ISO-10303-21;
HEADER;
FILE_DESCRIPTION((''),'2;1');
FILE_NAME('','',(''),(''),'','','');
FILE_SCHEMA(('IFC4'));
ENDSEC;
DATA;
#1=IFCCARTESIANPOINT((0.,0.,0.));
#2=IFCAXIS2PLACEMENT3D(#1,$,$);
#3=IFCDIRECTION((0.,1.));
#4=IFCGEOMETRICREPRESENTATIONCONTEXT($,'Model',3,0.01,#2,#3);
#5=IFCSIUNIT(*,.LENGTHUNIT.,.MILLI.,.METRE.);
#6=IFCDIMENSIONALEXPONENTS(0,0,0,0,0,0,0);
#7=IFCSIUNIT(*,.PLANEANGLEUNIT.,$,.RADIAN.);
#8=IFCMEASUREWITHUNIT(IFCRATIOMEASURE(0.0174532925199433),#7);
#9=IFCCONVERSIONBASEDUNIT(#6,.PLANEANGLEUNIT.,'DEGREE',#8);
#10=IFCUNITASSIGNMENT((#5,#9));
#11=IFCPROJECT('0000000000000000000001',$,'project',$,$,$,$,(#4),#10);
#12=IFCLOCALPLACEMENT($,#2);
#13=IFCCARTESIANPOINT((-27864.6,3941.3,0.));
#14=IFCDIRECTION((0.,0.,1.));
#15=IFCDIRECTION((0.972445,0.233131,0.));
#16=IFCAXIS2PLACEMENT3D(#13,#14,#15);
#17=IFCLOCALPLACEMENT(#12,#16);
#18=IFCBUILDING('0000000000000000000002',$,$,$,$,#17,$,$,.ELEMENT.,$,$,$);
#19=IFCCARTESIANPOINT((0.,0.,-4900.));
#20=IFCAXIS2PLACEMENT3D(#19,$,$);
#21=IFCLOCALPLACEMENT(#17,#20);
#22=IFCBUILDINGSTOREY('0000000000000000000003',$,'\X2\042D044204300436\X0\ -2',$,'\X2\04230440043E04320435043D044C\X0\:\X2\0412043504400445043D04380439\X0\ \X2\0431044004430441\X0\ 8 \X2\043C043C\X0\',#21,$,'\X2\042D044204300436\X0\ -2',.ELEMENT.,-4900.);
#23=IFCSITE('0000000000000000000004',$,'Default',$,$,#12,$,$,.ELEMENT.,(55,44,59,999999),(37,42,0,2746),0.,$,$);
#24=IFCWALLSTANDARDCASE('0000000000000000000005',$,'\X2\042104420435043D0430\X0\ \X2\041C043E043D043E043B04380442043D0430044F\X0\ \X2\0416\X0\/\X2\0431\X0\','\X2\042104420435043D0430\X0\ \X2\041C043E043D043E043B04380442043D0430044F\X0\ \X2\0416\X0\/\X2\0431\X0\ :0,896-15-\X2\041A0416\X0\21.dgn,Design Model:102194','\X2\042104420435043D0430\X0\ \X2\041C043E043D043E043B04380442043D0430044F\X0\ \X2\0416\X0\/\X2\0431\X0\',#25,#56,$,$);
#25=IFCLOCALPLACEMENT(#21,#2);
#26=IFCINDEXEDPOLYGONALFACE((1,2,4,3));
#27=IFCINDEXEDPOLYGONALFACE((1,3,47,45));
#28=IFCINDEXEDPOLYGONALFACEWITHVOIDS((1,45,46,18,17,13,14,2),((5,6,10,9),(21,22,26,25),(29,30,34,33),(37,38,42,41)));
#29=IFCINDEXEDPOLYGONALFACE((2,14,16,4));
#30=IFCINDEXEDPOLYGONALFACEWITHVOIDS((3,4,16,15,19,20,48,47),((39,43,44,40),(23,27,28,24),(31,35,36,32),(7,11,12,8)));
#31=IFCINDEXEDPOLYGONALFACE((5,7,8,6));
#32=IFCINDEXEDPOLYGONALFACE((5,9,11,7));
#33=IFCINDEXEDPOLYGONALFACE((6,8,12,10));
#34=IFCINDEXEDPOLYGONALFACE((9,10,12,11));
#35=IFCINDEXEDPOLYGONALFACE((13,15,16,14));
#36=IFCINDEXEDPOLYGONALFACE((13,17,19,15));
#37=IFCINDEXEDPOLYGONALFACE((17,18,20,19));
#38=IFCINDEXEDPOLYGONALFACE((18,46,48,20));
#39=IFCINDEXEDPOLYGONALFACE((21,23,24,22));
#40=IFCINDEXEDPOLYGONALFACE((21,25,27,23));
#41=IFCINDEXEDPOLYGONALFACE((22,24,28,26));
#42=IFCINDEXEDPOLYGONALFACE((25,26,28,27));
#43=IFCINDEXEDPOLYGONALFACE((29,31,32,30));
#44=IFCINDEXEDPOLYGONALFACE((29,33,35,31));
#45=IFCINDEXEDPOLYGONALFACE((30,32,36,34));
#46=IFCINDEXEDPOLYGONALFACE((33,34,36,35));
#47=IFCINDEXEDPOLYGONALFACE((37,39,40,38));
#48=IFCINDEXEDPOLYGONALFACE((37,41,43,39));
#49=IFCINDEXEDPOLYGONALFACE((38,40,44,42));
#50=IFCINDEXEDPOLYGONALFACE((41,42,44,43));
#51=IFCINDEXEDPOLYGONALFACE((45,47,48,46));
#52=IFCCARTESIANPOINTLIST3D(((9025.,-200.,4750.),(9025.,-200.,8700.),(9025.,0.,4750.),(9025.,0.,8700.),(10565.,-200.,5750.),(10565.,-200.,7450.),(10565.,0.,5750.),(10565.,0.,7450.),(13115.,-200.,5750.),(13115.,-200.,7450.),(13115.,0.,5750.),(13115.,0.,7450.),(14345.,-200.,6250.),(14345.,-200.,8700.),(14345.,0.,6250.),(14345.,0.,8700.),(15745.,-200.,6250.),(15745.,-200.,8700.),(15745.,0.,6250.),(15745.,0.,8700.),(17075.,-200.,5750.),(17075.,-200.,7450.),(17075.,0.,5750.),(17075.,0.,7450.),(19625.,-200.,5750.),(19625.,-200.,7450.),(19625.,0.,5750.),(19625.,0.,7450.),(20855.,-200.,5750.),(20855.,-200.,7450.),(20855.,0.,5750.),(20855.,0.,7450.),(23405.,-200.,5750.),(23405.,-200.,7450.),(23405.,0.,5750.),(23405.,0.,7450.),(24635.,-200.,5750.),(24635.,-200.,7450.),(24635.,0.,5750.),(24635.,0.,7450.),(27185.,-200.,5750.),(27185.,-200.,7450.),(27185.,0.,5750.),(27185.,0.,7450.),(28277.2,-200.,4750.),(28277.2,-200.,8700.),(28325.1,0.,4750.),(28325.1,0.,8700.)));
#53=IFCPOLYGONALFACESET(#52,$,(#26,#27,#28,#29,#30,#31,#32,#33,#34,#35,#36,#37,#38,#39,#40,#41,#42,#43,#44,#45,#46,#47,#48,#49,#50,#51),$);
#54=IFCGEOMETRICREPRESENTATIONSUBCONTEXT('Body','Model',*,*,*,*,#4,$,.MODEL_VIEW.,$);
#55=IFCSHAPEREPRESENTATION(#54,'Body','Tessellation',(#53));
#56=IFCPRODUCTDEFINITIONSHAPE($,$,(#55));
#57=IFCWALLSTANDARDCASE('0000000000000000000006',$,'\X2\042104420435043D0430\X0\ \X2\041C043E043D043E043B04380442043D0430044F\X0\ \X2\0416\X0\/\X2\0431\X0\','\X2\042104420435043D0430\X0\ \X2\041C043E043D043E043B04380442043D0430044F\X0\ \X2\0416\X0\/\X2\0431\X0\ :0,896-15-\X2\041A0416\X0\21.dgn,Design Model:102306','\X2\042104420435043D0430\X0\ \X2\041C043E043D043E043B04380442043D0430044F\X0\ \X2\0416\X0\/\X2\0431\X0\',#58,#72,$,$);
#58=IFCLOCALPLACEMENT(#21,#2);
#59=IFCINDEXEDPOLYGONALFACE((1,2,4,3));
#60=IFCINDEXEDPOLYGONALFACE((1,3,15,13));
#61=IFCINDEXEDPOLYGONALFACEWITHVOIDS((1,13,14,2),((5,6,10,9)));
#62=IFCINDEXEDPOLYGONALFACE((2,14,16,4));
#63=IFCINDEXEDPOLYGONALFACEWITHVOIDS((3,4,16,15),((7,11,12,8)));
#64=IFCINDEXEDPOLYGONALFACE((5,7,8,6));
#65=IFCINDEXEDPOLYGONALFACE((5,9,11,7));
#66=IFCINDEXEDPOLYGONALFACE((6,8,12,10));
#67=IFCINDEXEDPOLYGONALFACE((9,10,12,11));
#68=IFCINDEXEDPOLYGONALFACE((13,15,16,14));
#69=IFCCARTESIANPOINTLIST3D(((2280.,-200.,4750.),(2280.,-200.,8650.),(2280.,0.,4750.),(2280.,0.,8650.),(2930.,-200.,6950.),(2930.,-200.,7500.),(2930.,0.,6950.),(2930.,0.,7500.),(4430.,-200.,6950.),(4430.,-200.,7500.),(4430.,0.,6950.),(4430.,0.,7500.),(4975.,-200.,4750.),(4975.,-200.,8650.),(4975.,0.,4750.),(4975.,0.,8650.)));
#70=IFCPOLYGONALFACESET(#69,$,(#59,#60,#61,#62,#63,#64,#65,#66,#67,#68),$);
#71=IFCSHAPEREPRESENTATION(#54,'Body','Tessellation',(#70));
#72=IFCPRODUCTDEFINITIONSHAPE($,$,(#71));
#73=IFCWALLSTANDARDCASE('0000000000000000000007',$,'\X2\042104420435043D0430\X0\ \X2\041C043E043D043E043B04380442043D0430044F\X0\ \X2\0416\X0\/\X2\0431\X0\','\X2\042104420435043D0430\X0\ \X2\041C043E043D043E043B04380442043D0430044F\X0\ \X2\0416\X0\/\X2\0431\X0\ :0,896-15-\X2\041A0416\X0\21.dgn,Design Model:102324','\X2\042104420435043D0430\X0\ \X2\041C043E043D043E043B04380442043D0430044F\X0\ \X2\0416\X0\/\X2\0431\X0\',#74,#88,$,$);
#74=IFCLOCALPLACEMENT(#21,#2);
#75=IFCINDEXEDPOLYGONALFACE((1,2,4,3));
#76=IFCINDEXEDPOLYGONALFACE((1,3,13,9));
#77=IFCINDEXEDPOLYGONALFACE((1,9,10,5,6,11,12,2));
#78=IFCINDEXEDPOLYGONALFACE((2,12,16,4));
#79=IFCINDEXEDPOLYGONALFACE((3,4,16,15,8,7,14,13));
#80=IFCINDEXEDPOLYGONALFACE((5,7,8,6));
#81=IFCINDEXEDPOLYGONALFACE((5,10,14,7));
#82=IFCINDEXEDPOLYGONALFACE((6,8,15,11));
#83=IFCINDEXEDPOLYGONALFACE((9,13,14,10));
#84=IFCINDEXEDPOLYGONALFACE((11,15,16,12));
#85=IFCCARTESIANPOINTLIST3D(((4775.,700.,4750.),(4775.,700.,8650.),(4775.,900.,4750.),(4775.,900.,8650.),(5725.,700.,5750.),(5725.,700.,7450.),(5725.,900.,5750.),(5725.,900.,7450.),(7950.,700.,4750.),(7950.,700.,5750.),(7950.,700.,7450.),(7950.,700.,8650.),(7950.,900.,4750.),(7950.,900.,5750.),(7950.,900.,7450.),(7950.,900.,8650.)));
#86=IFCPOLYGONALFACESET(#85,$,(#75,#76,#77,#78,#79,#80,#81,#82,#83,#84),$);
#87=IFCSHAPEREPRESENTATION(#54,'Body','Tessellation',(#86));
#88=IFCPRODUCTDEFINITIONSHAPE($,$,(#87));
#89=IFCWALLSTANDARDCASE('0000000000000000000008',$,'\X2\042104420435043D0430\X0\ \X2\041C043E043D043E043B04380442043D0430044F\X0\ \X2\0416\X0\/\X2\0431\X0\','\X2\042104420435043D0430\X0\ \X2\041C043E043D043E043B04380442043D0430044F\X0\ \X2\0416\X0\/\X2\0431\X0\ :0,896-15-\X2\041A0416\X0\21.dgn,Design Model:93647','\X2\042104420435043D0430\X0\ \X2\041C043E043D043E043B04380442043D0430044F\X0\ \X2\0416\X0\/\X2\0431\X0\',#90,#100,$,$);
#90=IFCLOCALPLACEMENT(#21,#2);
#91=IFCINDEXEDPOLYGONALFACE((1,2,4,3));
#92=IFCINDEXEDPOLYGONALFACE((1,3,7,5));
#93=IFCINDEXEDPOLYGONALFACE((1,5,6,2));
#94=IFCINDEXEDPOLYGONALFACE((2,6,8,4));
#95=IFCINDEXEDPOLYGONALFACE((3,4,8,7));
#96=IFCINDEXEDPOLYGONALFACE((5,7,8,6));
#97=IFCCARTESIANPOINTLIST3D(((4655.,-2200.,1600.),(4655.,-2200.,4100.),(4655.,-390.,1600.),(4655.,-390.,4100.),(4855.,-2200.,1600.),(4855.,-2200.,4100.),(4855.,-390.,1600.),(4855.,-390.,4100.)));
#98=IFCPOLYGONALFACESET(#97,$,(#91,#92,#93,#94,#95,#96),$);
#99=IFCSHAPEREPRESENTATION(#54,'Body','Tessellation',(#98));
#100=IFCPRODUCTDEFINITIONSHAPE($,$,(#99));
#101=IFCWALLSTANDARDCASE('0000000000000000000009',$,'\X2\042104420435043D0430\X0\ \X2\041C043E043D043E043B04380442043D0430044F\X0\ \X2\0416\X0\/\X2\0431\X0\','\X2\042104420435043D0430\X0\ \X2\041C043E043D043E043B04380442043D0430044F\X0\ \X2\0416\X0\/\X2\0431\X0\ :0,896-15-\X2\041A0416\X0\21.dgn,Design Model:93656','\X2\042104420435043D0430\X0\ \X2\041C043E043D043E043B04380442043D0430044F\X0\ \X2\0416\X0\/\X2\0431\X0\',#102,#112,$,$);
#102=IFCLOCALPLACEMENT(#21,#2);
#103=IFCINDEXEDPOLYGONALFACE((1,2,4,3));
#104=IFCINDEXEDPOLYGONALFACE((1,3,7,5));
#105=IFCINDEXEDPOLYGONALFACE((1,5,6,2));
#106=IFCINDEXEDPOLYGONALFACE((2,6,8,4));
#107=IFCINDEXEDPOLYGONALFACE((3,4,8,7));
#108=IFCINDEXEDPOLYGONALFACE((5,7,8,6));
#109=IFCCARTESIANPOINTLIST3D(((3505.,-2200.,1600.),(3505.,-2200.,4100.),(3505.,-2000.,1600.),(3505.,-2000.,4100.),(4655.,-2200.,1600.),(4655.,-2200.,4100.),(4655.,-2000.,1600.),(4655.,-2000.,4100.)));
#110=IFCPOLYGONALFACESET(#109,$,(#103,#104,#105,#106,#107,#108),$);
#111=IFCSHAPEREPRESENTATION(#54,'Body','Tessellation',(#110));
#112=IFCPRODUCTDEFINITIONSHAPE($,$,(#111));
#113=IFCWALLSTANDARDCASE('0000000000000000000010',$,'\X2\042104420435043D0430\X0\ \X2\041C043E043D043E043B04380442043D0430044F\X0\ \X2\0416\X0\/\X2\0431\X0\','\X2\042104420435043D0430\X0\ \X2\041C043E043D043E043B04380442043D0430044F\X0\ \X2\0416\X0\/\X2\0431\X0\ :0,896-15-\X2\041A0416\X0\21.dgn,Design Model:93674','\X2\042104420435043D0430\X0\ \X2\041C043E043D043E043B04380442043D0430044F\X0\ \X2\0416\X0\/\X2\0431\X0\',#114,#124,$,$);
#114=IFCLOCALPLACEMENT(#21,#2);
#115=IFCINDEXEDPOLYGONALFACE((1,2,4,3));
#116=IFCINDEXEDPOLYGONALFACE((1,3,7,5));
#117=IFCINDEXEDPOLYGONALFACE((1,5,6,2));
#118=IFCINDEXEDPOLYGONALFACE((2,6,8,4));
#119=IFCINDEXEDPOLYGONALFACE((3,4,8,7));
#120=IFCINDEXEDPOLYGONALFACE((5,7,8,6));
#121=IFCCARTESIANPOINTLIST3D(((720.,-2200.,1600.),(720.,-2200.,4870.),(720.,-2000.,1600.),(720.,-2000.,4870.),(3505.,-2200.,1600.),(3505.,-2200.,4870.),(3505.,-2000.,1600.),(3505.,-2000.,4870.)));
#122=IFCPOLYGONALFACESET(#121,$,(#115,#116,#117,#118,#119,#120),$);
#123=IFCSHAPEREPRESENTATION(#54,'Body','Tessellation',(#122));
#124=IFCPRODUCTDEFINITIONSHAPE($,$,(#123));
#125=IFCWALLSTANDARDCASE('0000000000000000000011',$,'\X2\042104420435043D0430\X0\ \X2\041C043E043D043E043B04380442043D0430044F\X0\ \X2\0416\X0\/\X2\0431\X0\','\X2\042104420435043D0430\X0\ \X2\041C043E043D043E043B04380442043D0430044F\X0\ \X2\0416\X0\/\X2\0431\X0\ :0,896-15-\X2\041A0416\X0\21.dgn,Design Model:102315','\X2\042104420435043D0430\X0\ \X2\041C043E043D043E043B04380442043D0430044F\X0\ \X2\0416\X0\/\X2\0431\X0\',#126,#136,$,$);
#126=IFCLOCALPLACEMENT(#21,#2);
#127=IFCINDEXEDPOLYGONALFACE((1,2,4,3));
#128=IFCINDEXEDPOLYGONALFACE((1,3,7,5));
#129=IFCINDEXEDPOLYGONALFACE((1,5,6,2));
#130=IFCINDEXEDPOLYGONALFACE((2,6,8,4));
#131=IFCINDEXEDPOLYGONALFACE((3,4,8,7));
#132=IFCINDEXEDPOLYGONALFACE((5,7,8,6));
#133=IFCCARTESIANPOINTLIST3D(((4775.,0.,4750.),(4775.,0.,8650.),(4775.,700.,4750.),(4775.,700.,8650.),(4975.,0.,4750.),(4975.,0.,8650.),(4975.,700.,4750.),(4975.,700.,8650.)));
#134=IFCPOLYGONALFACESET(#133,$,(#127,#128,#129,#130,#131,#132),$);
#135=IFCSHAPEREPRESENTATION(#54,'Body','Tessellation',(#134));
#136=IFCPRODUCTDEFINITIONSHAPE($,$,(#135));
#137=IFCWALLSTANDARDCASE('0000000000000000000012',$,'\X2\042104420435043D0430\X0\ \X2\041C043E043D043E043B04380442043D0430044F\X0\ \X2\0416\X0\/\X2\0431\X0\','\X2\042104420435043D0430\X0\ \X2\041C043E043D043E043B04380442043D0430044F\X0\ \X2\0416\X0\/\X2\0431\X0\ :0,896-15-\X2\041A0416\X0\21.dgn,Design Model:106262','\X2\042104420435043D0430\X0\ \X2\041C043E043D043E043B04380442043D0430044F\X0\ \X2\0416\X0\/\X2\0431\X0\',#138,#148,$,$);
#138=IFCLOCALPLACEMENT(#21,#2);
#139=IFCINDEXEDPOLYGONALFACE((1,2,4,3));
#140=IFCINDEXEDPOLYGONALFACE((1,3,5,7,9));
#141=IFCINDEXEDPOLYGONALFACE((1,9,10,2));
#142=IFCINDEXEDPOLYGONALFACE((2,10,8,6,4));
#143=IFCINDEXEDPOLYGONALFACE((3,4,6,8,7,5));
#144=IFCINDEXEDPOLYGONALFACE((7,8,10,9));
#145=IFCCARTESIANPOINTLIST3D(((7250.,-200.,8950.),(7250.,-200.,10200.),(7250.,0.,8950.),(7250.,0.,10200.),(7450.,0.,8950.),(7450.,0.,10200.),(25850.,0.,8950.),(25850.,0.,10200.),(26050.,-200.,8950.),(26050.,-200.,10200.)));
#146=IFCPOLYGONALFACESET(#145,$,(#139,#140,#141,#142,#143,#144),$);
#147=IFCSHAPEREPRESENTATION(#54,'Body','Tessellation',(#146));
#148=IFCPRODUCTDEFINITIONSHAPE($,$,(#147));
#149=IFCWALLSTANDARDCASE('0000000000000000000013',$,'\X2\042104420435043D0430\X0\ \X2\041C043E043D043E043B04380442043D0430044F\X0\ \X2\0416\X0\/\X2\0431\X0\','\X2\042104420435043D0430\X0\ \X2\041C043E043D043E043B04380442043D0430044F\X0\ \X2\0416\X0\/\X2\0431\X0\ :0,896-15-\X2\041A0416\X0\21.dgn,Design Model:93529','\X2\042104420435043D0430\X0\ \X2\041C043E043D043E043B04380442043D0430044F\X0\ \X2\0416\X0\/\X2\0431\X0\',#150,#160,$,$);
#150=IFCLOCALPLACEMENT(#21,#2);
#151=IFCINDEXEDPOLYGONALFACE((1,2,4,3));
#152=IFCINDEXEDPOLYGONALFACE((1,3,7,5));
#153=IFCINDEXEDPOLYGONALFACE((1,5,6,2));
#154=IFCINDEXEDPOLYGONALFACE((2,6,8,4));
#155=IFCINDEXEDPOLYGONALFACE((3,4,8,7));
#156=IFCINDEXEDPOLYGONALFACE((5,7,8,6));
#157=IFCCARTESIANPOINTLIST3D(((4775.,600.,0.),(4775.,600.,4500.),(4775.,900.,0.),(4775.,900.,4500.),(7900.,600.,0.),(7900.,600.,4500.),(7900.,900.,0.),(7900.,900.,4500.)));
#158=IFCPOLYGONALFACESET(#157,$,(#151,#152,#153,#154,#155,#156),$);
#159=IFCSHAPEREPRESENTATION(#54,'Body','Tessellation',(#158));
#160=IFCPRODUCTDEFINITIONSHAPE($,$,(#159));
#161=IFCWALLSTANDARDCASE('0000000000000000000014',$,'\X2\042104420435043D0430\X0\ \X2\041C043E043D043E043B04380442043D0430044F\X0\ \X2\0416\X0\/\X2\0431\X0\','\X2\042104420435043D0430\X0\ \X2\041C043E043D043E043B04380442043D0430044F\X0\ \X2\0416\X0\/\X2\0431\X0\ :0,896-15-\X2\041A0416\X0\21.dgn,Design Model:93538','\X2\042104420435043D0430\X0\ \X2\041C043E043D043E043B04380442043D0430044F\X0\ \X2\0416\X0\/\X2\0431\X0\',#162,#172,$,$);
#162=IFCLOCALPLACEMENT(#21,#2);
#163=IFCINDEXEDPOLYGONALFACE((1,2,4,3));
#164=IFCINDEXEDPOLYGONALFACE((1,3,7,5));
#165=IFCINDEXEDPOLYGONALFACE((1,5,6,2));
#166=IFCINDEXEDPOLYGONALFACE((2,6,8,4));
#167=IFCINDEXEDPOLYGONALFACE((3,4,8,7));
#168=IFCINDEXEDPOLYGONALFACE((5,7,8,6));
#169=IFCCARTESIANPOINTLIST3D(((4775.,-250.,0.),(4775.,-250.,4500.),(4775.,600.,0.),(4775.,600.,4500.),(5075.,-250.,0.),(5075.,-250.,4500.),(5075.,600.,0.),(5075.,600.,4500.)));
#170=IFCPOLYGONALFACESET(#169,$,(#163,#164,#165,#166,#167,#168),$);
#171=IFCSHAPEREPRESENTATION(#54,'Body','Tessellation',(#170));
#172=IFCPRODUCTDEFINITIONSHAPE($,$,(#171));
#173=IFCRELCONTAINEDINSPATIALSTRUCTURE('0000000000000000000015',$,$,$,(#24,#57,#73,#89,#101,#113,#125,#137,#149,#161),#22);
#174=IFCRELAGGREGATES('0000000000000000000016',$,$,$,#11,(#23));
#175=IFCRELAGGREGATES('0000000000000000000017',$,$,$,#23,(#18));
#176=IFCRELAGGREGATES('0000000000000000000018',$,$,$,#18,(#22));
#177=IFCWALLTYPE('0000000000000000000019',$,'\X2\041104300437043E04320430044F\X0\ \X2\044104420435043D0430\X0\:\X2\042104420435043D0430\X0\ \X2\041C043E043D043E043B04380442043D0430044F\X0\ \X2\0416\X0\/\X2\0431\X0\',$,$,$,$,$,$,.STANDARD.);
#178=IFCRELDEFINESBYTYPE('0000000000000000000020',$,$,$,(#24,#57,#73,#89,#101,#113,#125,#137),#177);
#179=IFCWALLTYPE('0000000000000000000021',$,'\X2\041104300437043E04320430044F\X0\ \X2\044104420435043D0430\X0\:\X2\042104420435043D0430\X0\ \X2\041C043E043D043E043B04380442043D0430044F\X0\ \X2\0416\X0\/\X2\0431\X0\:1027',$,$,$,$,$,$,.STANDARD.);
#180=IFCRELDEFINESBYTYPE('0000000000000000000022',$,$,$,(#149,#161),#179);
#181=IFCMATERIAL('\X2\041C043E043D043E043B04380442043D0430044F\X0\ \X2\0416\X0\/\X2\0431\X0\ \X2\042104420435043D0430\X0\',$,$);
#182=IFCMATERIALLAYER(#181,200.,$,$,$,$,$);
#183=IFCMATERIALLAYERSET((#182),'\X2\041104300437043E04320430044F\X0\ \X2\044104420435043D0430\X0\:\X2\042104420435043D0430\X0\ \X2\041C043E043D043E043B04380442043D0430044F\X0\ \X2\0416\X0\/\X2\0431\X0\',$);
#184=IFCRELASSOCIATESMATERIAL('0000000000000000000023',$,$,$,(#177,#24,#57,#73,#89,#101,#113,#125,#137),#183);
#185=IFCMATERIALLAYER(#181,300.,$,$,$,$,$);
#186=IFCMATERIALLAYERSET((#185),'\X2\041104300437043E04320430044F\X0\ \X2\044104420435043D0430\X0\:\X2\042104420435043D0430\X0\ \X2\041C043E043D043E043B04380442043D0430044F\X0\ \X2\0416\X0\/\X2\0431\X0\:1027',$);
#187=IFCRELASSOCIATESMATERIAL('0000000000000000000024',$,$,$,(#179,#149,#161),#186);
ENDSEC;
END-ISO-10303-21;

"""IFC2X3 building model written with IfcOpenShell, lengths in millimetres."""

from ifc_helpers import new_model, entity, si_unit, converted_unit, direction, frame, frame_2d, origin, origin_2d_with_axis, place, context, subcontext, project, spatial, polyline, rectangle, outline, extrude, material, layer, layer_set, layer_usage, type_object, element, save


model = new_model("IFC2X3")

# Units and contexts
model_context = context("Model", 3, precision=0.01, world=origin(), true_north=direction((0.0, 1.0)))
body_context = subcontext(model_context, "Body", "Model", "MODEL_VIEW")
ifc_project = project(units=[si_unit("LENGTHUNIT", "METRE", prefix="MILLI"), converted_unit("PLANEANGLEUNIT", "DEGREE", entity("IfcRatioMeasure", 0.0174532925199433), si_unit("PLANEANGLEUNIT", "RADIAN"), dimensions=[0, 0, 0, 0, 0, 0, 0])], contexts=[model_context])

# Site, building, storey
site_placement = place(None, origin())
site = spatial("IfcSite", under=ifc_project, at=site_placement, Name="Default", CompositionType="ELEMENT", RefLatitude=(55, 44, 59, 999999), RefLongitude=(37, 42, 0, 2746), RefElevation=0.0)
building_placement = place(site_placement, frame((-27864.6, 3941.3, 0.0), z_axis=(0.0, 0.0, 1.0), x_axis=(0.972445, 0.233131, 0.0)))
building = spatial("IfcBuilding", under=site, at=building_placement, CompositionType="ELEMENT")
storey_placement = place(building_placement, frame((0.0, 0.0, -4900.0)))
storey = spatial("IfcBuildingStorey", under=building, at=storey_placement, Name="Этаж -2", ObjectType="Уровень:Верхний брус 8 мм", LongName="Этаж -2", CompositionType="ELEMENT", Elevation=-4900.0)

# Wall, openings
ifc_material = material(Name="Монолитная Ж/б Стена")
ifc_layer_1 = layer(ifc_material, 200.0)
ifc_layer_set_1 = layer_set([ifc_layer_1], Name="Базовая стена:Стена Монолитная Ж/б")
ifc_layer_usage_1 = layer_usage(ifc_layer_set_1, "AXIS2", "NEGATIVE", 100.0)
wall_type_1 = type_object("IfcWallType", Name="Базовая стена:Стена Монолитная Ж/б", PredefinedType="STANDARD", material=ifc_layer_set_1)
wall_1_placement = place(storey_placement, frame((9025.0, -100.0, 4750.0)))
wall_1 = element("IfcWallStandardCase", 1, at=wall_1_placement, inside=storey, type_object=wall_type_1, material=ifc_layer_usage_1, Name="Стена Монолитная Ж/б", Description="Стена Монолитная Ж/б :0,896-15-КЖ21.dgn,Design Model:102194", ObjectType="Стена Монолитная Ж/б", context=body_context, shape_type="SweptSolid", body=[
    extrude(outline(polyline([(19252.2, -100.0), (19300.1, 100.0), (7130.0, 100.0), (6880.0, 100.0), (200.0, 100.0), (0.0, 100.0), (0.0, -100.0), (19252.2, -100.0)])), origin(), (0.0, 0.0, 1.0), 3950.0),
])
placement = place(wall_1_placement, origin())
element("IfcOpeningElement", 2, at=placement, cuts=wall_1, ObjectType="Opening", context=body_context, shape_type="SweptSolid", body=[
    extrude(rectangle(XDim=1700.0, YDim=2550.0, at=origin_2d_with_axis()), frame((2815.0, -100.0, 1850.0), z_axis=(0.0, 1.0, 0.0), x_axis=(0.0, 0.0, -1.0)), (0.0, 0.0, 1.0), 200.0),
])
element("IfcOpeningElement", 3, at=placement, cuts=wall_1, ObjectType="Opening", context=body_context, shape_type="SweptSolid", body=[
    extrude(rectangle(XDim=1700.0, YDim=2550.0, at=origin_2d_with_axis()), frame((9325.0, -100.0, 1850.0), z_axis=(0.0, 1.0, 0.0), x_axis=(0.0, 0.0, -1.0)), (0.0, 0.0, 1.0), 200.0),
])
element("IfcOpeningElement", 4, at=placement, cuts=wall_1, ObjectType="Opening", context=body_context, shape_type="SweptSolid", body=[
    extrude(rectangle(XDim=1700.0, YDim=2550.0, at=origin_2d_with_axis()), frame((13105.0, -100.0, 1850.0), z_axis=(0.0, 1.0, 0.0), x_axis=(0.0, 0.0, -1.0)), (0.0, 0.0, 1.0), 200.0),
])
element("IfcOpeningElement", 5, at=placement, cuts=wall_1, ObjectType="Opening", context=body_context, shape_type="SweptSolid", body=[
    extrude(rectangle(XDim=1700.0, YDim=2550.0, at=origin_2d_with_axis()), frame((16885.0, -100.0, 1850.0), z_axis=(0.0, 1.0, 0.0), x_axis=(0.0, 0.0, -1.0)), (0.0, 0.0, 1.0), 200.0),
])
element("IfcOpeningElement", 6, at=placement, cuts=wall_1, ObjectType="Opening", context=body_context, shape_type="SweptSolid", body=[
    extrude(rectangle(XDim=2450.0, YDim=1400.0, at=origin_2d_with_axis()), frame((6020.0, -100.0, 2725.0), z_axis=(0.0, 1.0, 0.0), x_axis=(0.0, 0.0, -1.0)), (0.0, 0.0, 1.0), 200.0),
])

# Walls, openings
wall_2_placement = place(storey_placement, frame((4975.0, -100.0, 4750.0), z_axis=(0.0, 0.0, 1.0), x_axis=(-1.0, 0.0, 0.0)))
wall_2 = element("IfcWallStandardCase", 7, at=wall_2_placement, inside=storey, type_object=wall_type_1, material=ifc_layer_usage_1, Name="Стена Монолитная Ж/б", Description="Стена Монолитная Ж/б :0,896-15-КЖ21.dgn,Design Model:102306", ObjectType="Стена Монолитная Ж/б", context=body_context, shape_type="SweptSolid", body=[
    extrude(rectangle(XDim=2695.0, YDim=200.0, at=frame_2d((1347.5, 0.0), x_axis=(-1.0, 0.0))), origin(), (0.0, 0.0, 1.0), 3900.0),
])
opening_1_placement = place(wall_2_placement, origin())
element("IfcOpeningElement", 8, at=opening_1_placement, cuts=wall_2, ObjectType="Opening", context=body_context, shape_type="SweptSolid", body=[
    extrude(rectangle(XDim=550.0, YDim=1500.0, at=origin_2d_with_axis()), frame((1295.0, -100.0, 2475.0), z_axis=(0.0, 1.0, 0.0), x_axis=(0.0, 0.0, -1.0)), (0.0, 0.0, 1.0), 200.0),
])
wall_3_placement = place(storey_placement, frame((4775.0, 800.0, 4750.0)))
wall_3 = element("IfcWallStandardCase", 9, at=wall_3_placement, inside=storey, type_object=wall_type_1, material=ifc_layer_usage_1, Name="Стена Монолитная Ж/б", Description="Стена Монолитная Ж/б :0,896-15-КЖ21.dgn,Design Model:102324", ObjectType="Стена Монолитная Ж/б", context=body_context, shape_type="SweptSolid", body=[
    extrude(rectangle(XDim=3175.0, YDim=200.0, at=frame_2d((1587.5, 0.0), x_axis=(-1.0, 0.0))), origin(), (0.0, 0.0, 1.0), 3900.0),
])
opening_2_placement = place(wall_3_placement, origin())
element("IfcOpeningElement", 10, at=opening_2_placement, cuts=wall_3, ObjectType="Opening", context=body_context, shape_type="SweptSolid", body=[
    extrude(rectangle(XDim=1700.0, YDim=2550.0, at=origin_2d_with_axis()), frame((2225.0, -100.0, 1850.0), z_axis=(0.0, 1.0, 0.0), x_axis=(0.0, 0.0, -1.0)), (0.0, 0.0, 1.0), 200.0),
])

# Walls
wall_4_placement = place(storey_placement, frame((4755.0, -2200.0, 1600.0), z_axis=(0.0, 0.0, 1.0), x_axis=(0.0, 1.0, 0.0)))
element("IfcWallStandardCase", 11, at=wall_4_placement, inside=storey, type_object=wall_type_1, material=ifc_layer_usage_1, Name="Стена Монолитная Ж/б", Description="Стена Монолитная Ж/б :0,896-15-КЖ21.dgn,Design Model:93647", ObjectType="Стена Монолитная Ж/б", context=body_context, shape_type="SweptSolid", body=[
    extrude(rectangle(XDim=1810.0, YDim=200.0, at=frame_2d((905.0, 0.0), x_axis=(-1.0, 0.0))), origin(), (0.0, 0.0, 1.0), 2500.0),
])
wall_5_placement = place(storey_placement, frame((3505.0, -2100.0, 1600.0)))
element("IfcWallStandardCase", 12, at=wall_5_placement, inside=storey, type_object=wall_type_1, material=ifc_layer_usage_1, Name="Стена Монолитная Ж/б", Description="Стена Монолитная Ж/б :0,896-15-КЖ21.dgn,Design Model:93656", ObjectType="Стена Монолитная Ж/б", context=body_context, shape_type="SweptSolid", body=[
    extrude(rectangle(XDim=1150.0, YDim=200.0, at=frame_2d((575.0, 0.0), x_axis=(-1.0, 0.0))), origin(), (0.0, 0.0, 1.0), 2500.0),
])
wall_6_placement = place(storey_placement, frame((3505.0, -2100.0, 1600.0), z_axis=(0.0, 0.0, 1.0), x_axis=(-1.0, 0.0, 0.0)))
element("IfcWallStandardCase", 13, at=wall_6_placement, inside=storey, type_object=wall_type_1, material=ifc_layer_usage_1, Name="Стена Монолитная Ж/б", Description="Стена Монолитная Ж/б :0,896-15-КЖ21.dgn,Design Model:93674", ObjectType="Стена Монолитная Ж/б", context=body_context, shape_type="SweptSolid", body=[
    extrude(rectangle(XDim=2785.0, YDim=200.0, at=frame_2d((1392.5, 0.0), x_axis=(-1.0, 0.0))), origin(), (0.0, 0.0, 1.0), 3270.0),
])
wall_7_placement = place(storey_placement, frame((4875.0, 700.0, 4750.0), z_axis=(0.0, 0.0, 1.0), x_axis=(0.0, -1.0, 0.0)))
element("IfcWallStandardCase", 14, at=wall_7_placement, inside=storey, type_object=wall_type_1, material=ifc_layer_usage_1, Name="Стена Монолитная Ж/б", Description="Стена Монолитная Ж/б :0,896-15-КЖ21.dgn,Design Model:102315", ObjectType="Стена Монолитная Ж/б", context=body_context, shape_type="SweptSolid", body=[
    extrude(rectangle(XDim=700.0, YDim=200.0, at=frame_2d((350.0, 0.0), x_axis=(-1.0, 0.0))), origin(), (0.0, 0.0, 1.0), 3900.0),
])
wall_8_placement = place(storey_placement, frame((7250.0, -100.0, 8950.0)))
element("IfcWallStandardCase", 15, at=wall_8_placement, inside=storey, type_object=wall_type_1, material=ifc_layer_usage_1, Name="Стена Монолитная Ж/б", Description="Стена Монолитная Ж/б :0,896-15-КЖ21.dgn,Design Model:106262", ObjectType="Стена Монолитная Ж/б", context=body_context, shape_type="SweptSolid", body=[
    extrude(outline(polyline([(18800.0, -100.0), (18600.0, 100.0), (200.0, 100.0), (0.0, 100.0), (0.0, -100.0), (18800.0, -100.0)])), origin(), (0.0, 0.0, 1.0), 1250.0),
])
ifc_layer_2 = layer(ifc_material, 300.0)
ifc_layer_set_2 = layer_set([ifc_layer_2], Name="Базовая стена:Стена Монолитная Ж/б:1027")
ifc_layer_usage_2 = layer_usage(ifc_layer_set_2, "AXIS2", "NEGATIVE", 150.0)
wall_type_2 = type_object("IfcWallType", Name="Базовая стена:Стена Монолитная Ж/б:1027", PredefinedType="STANDARD", material=ifc_layer_set_2)
wall_9_placement = place(storey_placement, frame((4775.0, 750.0, 0.0)))
element("IfcWallStandardCase", 16, at=wall_9_placement, inside=storey, type_object=wall_type_2, material=ifc_layer_usage_2, Name="Стена Монолитная Ж/б", Description="Стена Монолитная Ж/б :0,896-15-КЖ21.dgn,Design Model:93529", ObjectType="Стена Монолитная Ж/б", context=body_context, shape_type="SweptSolid", body=[
    extrude(rectangle(XDim=3125.0, YDim=300.0, at=frame_2d((1562.5, 0.0), x_axis=(-1.0, 0.0))), origin(), (0.0, 0.0, 1.0), 4500.0),
])
wall_10_placement = place(storey_placement, frame((4925.0, -250.0, 0.0), z_axis=(0.0, 0.0, 1.0), x_axis=(0.0, 1.0, 0.0)))
element("IfcWallStandardCase", 17, at=wall_10_placement, inside=storey, type_object=wall_type_2, material=ifc_layer_usage_2, Name="Стена Монолитная Ж/б", Description="Стена Монолитная Ж/б :0,896-15-КЖ21.dgn,Design Model:93538", ObjectType="Стена Монолитная Ж/б", context=body_context, shape_type="SweptSolid", body=[
    extrude(rectangle(XDim=850.0, YDim=300.0, at=frame_2d((425.0, 0.0), x_axis=(-1.0, 0.0))), origin(), (0.0, 0.0, 1.0), 4500.0),
])

save(model, "model.ifc")
